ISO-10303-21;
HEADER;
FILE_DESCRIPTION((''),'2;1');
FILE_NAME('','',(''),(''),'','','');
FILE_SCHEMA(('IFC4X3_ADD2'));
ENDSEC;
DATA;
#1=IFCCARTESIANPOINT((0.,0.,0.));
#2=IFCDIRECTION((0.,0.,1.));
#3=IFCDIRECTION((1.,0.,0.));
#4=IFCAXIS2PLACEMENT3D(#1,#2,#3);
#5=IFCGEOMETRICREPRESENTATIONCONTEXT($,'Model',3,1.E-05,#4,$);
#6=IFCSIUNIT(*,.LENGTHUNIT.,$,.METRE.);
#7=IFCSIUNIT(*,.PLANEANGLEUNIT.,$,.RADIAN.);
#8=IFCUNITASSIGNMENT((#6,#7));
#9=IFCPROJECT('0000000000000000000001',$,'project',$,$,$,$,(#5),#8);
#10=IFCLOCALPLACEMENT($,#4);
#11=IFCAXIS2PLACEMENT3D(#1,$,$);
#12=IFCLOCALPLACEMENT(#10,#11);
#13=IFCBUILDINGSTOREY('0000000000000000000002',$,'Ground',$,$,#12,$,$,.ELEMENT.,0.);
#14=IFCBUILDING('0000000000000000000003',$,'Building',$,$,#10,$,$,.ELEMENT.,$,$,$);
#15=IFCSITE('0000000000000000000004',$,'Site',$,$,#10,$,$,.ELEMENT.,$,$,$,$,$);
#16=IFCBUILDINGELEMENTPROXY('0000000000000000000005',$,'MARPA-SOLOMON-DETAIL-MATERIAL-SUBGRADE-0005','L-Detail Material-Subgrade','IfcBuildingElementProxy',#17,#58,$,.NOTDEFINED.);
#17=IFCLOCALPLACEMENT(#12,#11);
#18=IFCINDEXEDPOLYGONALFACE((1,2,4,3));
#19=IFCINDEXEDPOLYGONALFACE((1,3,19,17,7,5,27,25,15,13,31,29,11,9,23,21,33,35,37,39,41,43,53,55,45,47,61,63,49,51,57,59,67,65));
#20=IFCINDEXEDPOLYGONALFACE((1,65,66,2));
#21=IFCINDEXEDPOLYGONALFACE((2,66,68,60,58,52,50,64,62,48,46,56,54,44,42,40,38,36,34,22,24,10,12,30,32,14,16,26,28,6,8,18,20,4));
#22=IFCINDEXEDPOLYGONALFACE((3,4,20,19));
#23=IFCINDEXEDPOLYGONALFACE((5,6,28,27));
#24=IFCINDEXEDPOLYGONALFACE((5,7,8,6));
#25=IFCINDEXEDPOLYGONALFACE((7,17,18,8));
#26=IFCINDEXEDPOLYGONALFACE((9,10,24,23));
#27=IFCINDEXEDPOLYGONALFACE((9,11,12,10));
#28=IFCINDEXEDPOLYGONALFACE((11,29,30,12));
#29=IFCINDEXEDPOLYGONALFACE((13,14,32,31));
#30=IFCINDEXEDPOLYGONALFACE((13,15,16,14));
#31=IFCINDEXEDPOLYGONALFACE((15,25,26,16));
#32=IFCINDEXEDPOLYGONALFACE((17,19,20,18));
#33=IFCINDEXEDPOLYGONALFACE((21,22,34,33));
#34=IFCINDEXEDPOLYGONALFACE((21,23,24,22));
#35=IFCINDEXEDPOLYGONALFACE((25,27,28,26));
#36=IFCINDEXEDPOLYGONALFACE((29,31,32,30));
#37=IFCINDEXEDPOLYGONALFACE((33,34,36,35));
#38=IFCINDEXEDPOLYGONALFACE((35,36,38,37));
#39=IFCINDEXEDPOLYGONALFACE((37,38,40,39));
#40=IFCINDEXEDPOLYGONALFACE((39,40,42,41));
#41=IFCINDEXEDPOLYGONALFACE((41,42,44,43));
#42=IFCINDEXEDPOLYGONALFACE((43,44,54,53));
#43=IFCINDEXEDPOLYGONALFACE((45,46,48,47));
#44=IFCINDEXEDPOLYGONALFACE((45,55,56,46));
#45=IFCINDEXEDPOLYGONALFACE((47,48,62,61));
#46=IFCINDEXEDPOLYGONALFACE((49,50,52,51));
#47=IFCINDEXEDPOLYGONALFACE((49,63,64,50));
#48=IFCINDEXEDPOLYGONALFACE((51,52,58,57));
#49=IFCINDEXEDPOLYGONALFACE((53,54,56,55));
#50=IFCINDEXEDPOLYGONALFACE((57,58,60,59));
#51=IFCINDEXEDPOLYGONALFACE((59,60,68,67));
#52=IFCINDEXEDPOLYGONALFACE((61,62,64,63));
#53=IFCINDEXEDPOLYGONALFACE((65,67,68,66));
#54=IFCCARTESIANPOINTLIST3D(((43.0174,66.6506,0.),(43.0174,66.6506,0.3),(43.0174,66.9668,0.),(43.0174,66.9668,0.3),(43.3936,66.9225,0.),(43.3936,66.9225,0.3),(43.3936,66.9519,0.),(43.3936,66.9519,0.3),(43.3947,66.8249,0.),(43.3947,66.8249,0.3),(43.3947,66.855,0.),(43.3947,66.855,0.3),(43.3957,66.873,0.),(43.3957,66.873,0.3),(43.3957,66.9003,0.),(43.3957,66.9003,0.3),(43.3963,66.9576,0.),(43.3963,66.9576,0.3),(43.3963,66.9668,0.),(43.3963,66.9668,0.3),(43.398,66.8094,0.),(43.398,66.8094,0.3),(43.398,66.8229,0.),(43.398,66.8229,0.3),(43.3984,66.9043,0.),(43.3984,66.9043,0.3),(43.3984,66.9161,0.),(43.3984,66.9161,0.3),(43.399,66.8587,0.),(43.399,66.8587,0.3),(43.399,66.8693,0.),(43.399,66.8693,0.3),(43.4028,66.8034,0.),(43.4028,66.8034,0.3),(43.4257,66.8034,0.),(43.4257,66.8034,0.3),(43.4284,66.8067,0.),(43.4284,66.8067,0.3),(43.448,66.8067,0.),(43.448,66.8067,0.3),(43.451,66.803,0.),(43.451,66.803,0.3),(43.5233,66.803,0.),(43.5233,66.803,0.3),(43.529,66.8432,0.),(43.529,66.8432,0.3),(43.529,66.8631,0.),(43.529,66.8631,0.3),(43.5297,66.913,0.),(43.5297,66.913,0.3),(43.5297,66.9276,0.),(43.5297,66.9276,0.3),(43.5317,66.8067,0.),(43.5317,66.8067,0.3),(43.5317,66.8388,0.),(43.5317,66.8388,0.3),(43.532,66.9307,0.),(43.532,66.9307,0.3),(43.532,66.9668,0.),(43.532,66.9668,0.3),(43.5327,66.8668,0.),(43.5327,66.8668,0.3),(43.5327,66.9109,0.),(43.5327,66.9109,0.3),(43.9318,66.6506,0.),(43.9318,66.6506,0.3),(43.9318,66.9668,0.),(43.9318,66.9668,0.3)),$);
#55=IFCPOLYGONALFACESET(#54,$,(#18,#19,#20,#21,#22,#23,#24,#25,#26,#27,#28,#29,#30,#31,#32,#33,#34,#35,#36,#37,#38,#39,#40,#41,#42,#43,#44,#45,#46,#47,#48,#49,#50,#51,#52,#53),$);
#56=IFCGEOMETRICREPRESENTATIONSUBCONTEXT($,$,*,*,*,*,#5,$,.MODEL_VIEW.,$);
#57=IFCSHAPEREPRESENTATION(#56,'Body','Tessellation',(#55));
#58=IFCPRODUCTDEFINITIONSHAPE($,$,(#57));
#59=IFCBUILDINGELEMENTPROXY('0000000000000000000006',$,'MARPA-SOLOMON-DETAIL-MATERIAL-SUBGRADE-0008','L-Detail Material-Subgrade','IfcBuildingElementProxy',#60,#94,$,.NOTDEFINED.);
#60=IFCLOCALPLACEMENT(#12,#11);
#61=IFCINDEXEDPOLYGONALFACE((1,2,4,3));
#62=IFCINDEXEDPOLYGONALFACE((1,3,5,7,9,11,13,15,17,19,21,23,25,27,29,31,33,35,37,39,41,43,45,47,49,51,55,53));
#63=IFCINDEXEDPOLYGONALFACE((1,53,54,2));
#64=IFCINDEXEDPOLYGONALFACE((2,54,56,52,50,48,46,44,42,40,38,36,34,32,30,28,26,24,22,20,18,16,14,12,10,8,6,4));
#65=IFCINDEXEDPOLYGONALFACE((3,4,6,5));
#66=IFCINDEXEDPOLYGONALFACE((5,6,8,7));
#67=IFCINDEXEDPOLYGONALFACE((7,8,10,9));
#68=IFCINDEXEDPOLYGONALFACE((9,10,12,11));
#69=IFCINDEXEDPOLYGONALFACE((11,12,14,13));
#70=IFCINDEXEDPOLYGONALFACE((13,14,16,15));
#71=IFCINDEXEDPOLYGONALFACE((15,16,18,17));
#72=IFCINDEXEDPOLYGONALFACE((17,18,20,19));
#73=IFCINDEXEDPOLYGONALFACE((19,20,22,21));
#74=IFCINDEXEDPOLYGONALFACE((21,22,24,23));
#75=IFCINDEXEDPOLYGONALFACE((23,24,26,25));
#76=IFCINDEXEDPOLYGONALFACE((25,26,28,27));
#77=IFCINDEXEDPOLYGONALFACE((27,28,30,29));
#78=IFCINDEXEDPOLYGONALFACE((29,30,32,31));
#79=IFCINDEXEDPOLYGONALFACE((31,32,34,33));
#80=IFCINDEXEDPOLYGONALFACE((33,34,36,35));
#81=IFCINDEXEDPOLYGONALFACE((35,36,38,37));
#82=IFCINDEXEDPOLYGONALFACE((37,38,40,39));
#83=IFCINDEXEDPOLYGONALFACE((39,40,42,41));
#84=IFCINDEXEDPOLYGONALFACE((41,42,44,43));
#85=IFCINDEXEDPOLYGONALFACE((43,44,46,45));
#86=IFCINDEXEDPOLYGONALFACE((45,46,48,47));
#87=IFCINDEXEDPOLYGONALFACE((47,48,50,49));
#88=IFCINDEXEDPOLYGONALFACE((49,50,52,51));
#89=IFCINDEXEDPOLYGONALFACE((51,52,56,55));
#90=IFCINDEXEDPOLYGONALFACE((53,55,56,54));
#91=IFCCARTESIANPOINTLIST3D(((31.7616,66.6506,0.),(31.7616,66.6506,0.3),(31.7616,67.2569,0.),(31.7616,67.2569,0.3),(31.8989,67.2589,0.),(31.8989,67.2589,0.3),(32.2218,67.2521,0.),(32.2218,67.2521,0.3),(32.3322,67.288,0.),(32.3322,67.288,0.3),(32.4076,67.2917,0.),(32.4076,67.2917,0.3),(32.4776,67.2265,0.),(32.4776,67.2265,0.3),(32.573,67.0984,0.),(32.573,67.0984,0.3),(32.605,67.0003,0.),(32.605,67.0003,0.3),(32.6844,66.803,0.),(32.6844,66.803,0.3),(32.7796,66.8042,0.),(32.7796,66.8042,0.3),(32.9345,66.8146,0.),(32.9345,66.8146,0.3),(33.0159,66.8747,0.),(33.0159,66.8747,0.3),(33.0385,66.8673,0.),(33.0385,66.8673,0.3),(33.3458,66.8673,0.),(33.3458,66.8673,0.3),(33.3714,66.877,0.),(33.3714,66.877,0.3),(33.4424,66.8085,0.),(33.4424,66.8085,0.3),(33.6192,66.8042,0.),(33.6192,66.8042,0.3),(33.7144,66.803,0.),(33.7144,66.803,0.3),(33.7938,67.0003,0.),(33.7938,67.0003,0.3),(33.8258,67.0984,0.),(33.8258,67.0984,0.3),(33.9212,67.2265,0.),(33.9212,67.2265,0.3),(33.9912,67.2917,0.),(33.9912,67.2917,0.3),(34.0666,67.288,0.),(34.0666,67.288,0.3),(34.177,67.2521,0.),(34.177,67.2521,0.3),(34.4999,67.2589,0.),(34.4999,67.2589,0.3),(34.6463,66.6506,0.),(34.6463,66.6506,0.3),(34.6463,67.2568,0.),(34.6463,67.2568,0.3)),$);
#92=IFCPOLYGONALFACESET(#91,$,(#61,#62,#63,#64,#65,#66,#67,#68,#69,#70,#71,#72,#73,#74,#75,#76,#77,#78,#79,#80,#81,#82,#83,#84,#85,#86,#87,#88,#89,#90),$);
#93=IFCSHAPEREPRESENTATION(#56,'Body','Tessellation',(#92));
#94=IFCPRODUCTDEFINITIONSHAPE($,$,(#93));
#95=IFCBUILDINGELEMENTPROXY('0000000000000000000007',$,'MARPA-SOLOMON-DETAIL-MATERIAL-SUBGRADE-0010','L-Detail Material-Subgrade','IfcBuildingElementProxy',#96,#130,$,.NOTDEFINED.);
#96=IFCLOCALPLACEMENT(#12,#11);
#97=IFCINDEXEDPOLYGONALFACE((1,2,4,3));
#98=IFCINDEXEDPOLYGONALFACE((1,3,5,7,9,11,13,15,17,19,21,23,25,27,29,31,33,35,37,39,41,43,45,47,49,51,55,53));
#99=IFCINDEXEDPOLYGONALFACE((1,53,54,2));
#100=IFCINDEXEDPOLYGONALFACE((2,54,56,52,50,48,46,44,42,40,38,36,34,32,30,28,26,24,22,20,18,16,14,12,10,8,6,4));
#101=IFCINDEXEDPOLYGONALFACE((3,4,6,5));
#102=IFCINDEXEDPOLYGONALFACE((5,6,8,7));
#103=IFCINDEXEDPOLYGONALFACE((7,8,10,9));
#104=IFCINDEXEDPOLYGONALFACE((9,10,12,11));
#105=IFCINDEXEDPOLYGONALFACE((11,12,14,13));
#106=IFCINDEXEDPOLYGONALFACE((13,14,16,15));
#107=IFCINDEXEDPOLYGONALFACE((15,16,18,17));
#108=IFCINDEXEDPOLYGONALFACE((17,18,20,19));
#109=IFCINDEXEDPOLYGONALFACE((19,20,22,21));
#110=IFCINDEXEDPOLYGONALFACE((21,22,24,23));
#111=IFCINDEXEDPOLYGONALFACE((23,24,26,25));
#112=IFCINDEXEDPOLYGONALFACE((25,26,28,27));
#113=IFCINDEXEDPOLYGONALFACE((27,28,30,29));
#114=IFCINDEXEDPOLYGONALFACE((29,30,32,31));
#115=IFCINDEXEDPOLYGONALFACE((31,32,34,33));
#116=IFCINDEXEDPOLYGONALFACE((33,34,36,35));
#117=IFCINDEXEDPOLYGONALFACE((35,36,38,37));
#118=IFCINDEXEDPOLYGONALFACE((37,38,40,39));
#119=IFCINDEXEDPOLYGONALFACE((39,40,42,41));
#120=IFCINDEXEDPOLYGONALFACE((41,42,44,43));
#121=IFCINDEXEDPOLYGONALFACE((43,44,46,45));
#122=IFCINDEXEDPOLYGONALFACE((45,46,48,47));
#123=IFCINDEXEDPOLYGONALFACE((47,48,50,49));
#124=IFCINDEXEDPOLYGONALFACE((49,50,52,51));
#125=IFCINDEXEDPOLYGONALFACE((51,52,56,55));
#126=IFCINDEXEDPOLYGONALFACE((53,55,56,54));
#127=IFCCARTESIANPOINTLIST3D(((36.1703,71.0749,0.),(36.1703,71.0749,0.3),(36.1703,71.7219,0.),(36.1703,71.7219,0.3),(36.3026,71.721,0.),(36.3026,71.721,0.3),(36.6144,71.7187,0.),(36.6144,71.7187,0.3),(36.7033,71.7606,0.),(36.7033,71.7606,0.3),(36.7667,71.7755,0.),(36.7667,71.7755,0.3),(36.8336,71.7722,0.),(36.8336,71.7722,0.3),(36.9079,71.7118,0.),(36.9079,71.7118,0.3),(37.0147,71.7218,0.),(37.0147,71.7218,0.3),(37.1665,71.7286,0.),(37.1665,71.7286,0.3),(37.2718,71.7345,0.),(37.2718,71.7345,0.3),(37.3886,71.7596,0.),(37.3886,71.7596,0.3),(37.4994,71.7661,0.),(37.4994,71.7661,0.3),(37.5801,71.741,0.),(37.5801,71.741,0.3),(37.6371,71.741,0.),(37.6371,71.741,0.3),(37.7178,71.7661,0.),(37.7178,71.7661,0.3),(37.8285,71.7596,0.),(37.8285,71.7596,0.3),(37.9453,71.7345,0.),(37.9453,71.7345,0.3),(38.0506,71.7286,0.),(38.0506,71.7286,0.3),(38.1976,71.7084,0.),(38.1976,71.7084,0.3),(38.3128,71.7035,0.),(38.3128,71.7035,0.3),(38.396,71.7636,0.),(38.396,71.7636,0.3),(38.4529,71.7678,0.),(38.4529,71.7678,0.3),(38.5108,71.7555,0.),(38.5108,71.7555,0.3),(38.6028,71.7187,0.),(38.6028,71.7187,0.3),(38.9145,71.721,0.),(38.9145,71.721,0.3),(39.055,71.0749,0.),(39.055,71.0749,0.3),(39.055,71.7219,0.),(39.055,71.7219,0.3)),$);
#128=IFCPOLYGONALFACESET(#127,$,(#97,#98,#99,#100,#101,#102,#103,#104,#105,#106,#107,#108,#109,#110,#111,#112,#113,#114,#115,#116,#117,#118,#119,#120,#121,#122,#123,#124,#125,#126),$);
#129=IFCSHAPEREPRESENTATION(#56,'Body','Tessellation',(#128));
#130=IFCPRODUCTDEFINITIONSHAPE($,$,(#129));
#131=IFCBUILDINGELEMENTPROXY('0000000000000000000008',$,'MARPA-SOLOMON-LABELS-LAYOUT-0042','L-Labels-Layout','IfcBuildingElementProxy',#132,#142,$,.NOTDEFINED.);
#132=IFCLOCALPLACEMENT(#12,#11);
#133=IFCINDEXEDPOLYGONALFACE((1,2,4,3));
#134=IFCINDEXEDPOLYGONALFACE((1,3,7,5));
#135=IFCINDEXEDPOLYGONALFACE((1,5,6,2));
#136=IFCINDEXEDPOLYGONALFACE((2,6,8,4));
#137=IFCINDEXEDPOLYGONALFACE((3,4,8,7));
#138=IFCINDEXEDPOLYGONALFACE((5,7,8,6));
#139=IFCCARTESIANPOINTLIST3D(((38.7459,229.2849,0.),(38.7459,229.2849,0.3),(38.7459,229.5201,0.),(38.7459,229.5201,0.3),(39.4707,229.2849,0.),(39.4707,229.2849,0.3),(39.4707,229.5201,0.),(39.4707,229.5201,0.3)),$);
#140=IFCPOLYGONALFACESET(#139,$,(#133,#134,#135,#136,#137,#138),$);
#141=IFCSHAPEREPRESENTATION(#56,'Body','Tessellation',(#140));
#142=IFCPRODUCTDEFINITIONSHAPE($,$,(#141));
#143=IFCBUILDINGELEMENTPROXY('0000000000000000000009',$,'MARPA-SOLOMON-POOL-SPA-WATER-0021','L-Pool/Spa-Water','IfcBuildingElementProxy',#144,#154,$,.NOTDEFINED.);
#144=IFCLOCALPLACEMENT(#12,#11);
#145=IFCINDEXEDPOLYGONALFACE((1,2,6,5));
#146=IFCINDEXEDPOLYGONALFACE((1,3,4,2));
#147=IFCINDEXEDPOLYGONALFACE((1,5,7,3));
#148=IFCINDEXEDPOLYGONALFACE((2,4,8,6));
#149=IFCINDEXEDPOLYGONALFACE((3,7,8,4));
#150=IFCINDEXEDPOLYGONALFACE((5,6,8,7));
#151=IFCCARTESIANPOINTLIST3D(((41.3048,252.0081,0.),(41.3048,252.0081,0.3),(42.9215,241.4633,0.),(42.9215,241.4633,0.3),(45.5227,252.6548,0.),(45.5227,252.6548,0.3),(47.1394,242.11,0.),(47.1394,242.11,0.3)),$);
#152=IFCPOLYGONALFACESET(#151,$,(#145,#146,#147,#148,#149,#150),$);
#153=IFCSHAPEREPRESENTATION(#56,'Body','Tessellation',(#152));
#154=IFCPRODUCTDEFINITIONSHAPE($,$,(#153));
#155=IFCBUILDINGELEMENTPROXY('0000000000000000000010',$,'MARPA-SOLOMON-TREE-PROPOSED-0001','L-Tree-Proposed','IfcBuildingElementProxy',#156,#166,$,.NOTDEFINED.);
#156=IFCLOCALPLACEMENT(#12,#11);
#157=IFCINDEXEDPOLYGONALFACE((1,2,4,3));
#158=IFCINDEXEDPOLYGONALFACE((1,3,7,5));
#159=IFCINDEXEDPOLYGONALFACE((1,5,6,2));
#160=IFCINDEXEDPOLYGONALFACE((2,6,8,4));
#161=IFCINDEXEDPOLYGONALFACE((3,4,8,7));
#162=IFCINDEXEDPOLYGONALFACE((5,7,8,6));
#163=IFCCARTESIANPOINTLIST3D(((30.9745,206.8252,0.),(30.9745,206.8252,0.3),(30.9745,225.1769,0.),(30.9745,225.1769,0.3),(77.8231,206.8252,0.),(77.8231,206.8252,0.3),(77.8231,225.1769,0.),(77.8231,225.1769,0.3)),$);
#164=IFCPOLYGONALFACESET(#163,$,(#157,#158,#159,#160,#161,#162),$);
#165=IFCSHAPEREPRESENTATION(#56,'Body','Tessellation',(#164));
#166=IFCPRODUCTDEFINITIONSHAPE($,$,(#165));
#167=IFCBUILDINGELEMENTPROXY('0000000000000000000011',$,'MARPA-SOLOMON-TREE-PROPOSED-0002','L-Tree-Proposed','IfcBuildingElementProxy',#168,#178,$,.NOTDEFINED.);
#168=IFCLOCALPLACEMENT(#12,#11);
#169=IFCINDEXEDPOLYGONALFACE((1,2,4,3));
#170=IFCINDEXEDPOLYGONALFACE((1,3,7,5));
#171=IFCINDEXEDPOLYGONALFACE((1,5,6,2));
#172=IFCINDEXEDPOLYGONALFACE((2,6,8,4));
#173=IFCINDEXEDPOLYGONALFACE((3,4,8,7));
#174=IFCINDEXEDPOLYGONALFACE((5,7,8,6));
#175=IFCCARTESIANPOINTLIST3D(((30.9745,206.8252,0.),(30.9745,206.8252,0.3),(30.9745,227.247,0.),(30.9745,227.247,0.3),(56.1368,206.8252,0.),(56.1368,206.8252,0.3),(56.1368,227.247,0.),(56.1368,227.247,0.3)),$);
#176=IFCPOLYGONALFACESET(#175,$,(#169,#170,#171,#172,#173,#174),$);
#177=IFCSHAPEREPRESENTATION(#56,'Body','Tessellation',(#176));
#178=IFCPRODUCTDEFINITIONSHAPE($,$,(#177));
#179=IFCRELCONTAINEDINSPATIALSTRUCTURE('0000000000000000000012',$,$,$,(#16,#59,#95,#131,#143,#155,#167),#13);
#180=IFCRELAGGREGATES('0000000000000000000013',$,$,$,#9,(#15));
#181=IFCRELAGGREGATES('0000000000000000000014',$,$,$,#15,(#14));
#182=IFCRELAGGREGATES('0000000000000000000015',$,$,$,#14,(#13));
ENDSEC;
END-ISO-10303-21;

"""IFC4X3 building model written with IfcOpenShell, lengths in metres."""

from ifc_helpers import new_model, si_unit, frame, frame_2d, origin, origin_with_axes, place, context, subcontext, project, spatial, polyline, rectangle, outline, extrude, element, save


model = new_model("IFC4X3")

# Units and contexts
model_context = context("Model", 3, precision=1e-05, world=origin_with_axes())
sub_context = subcontext(model_context, None, None, "MODEL_VIEW")
ifc_project = project(units=[si_unit("LENGTHUNIT", "METRE"), si_unit("PLANEANGLEUNIT", "RADIAN")], contexts=[model_context])

# Site, building, storey
placement = place(None, origin_with_axes())
site = spatial("IfcSite", under=ifc_project, at=placement, Name="Site", CompositionType="ELEMENT")
building = spatial("IfcBuilding", under=site, at=placement, Name="Building", CompositionType="ELEMENT")
storey_placement = place(placement, origin())
storey = spatial("IfcBuildingStorey", under=building, at=storey_placement, Name="Ground", CompositionType="ELEMENT", Elevation=0.0)

# Building element proxies
proxy_1_placement = place(placement, frame((43.0174, 66.6506, 0.0)))
element("IfcBuildingElementProxy", 1, at=proxy_1_placement, inside=storey, Name="MARPA-SOLOMON-DETAIL-MATERIAL-SUBGRADE-0005", Description="L-Detail Material-Subgrade", ObjectType="IfcBuildingElementProxy", PredefinedType="NOTDEFINED", context=sub_context, shape_type="SweptSolid", body=[
    extrude(outline(polyline([(0.0, 0.0), (0.9144, 0.0), (0.9144, 0.3161), (0.5147, 0.3161), (0.5147, 0.28), (0.5123, 0.277), (0.5123, 0.2623), (0.5154, 0.2603), (0.5154, 0.2161), (0.5117, 0.2124), (0.5117, 0.1925), (0.5144, 0.1881), (0.5144, 0.1561), (0.5059, 0.1524), (0.4337, 0.1524), (0.4306, 0.1561), (0.4111, 0.1561), (0.4084, 0.1527), (0.3854, 0.1527), (0.3807, 0.1588), (0.3807, 0.1723), (0.3773, 0.1743), (0.3773, 0.2043), (0.3817, 0.208), (0.3817, 0.2186), (0.3783, 0.2223), (0.3783, 0.2496), (0.381, 0.2537), (0.381, 0.2655), (0.3763, 0.2719), (0.3763, 0.3012), (0.379, 0.307), (0.379, 0.3161), (0.0, 0.3161), (0.0, 0.0)])), origin(), (0.0, 0.0, 1.0), 0.3),
])
proxy_2_placement = place(placement, frame((31.7616, 66.6506, 0.0)))
element("IfcBuildingElementProxy", 2, at=proxy_2_placement, inside=storey, Name="MARPA-SOLOMON-DETAIL-MATERIAL-SUBGRADE-0008", Description="L-Detail Material-Subgrade", ObjectType="IfcBuildingElementProxy", PredefinedType="NOTDEFINED", context=sub_context, shape_type="SweptSolid", body=[
    extrude(outline(polyline([(0.0, 0.0), (2.8847, 0.0), (2.8847, 0.6061), (2.7384, 0.6083), (2.4154, 0.6015), (2.305, 0.6373), (2.2296, 0.641), (2.1596, 0.5759), (2.0642, 0.4478), (2.0322, 0.3497), (1.9529, 0.1524), (1.8577, 0.1536), (1.6809, 0.1579), (1.6098, 0.2263), (1.5842, 0.2167), (1.277, 0.2167), (1.2543, 0.2241), (1.173, 0.1639), (1.018, 0.1536), (0.9228, 0.1524), (0.8435, 0.3497), (0.8115, 0.4478), (0.716, 0.5759), (0.646, 0.641), (0.5706, 0.6373), (0.4602, 0.6015), (0.1373, 0.6083), (0.0, 0.6063), (0.0, 0.0)])), origin(), (0.0, 0.0, 1.0), 0.3),
])
proxy_3_placement = place(placement, frame((36.1703, 71.0749, 0.0)))
element("IfcBuildingElementProxy", 3, at=proxy_3_placement, inside=storey, Name="MARPA-SOLOMON-DETAIL-MATERIAL-SUBGRADE-0010", Description="L-Detail Material-Subgrade", ObjectType="IfcBuildingElementProxy", PredefinedType="NOTDEFINED", context=sub_context, shape_type="SweptSolid", body=[
    extrude(outline(polyline([(2.8847, 0.647), (2.7443, 0.6461), (2.4325, 0.6438), (2.3406, 0.6806), (2.2826, 0.6929), (2.2258, 0.6887), (2.1426, 0.6286), (2.0273, 0.6335), (1.8804, 0.6537), (1.7751, 0.6596), (1.6583, 0.6847), (1.5476, 0.6912), (1.4668, 0.6661), (1.4098, 0.6661), (1.3291, 0.6912), (1.2184, 0.6847), (1.1016, 0.6596), (0.9963, 0.6537), (0.8444, 0.6469), (0.7377, 0.6369), (0.6633, 0.6973), (0.5965, 0.7006), (0.533, 0.6857), (0.4441, 0.6438), (0.1324, 0.6461), (0.0, 0.647), (0.0, 0.0), (2.8847, 0.0), (2.8847, 0.647)])), origin(), (0.0, 0.0, 1.0), 0.3),
])
proxy_4_placement = place(placement, frame((38.7459, 229.2849, 0.0)))
element("IfcBuildingElementProxy", 4, at=proxy_4_placement, inside=storey, Name="MARPA-SOLOMON-LABELS-LAYOUT-0042", Description="L-Labels-Layout", ObjectType="IfcBuildingElementProxy", PredefinedType="NOTDEFINED", context=sub_context, shape_type="SweptSolid", body=[
    extrude(rectangle(XDim=0.7248, YDim=0.2352, at=frame_2d((0.3624, 0.1176))), origin(), (0.0, 0.0, 1.0), 0.3),
])
proxy_5_placement = place(placement, frame((41.3048, 241.4633, 0.0)))
element("IfcBuildingElementProxy", 5, at=proxy_5_placement, inside=storey, Name="MARPA-SOLOMON-POOL-SPA-WATER-0021", Description="L-Pool/Spa-Water", ObjectType="IfcBuildingElementProxy", PredefinedType="NOTDEFINED", context=sub_context, shape_type="SweptSolid", body=[
    extrude(outline(polyline([(0.0, 10.5448), (4.2179, 11.1915), (5.8346, 0.6467), (1.6167, 0.0), (0.0, 10.5448)])), origin(), (0.0, 0.0, 1.0), 0.3),
])
proxy_6_placement = place(placement, frame((30.9745, 206.8252, 0.0)))
element("IfcBuildingElementProxy", 6, at=proxy_6_placement, inside=storey, Name="MARPA-SOLOMON-TREE-PROPOSED-0001", Description="L-Tree-Proposed", ObjectType="IfcBuildingElementProxy", PredefinedType="NOTDEFINED", context=sub_context, shape_type="SweptSolid", body=[
    extrude(rectangle(XDim=46.8486, YDim=18.3517, at=frame_2d((23.4243, 9.1759))), origin(), (0.0, 0.0, 1.0), 0.3),
])
proxy_7_placement = place(placement, frame((30.9745, 206.8252, 0.0)))
element("IfcBuildingElementProxy", 7, at=proxy_7_placement, inside=storey, Name="MARPA-SOLOMON-TREE-PROPOSED-0002", Description="L-Tree-Proposed", ObjectType="IfcBuildingElementProxy", PredefinedType="NOTDEFINED", context=sub_context, shape_type="SweptSolid", body=[
    extrude(rectangle(XDim=25.1623, YDim=20.4218, at=frame_2d((12.5811, 10.2109))), origin(), (0.0, 0.0, 1.0), 0.3),
])

save(model, "model.ifc")
